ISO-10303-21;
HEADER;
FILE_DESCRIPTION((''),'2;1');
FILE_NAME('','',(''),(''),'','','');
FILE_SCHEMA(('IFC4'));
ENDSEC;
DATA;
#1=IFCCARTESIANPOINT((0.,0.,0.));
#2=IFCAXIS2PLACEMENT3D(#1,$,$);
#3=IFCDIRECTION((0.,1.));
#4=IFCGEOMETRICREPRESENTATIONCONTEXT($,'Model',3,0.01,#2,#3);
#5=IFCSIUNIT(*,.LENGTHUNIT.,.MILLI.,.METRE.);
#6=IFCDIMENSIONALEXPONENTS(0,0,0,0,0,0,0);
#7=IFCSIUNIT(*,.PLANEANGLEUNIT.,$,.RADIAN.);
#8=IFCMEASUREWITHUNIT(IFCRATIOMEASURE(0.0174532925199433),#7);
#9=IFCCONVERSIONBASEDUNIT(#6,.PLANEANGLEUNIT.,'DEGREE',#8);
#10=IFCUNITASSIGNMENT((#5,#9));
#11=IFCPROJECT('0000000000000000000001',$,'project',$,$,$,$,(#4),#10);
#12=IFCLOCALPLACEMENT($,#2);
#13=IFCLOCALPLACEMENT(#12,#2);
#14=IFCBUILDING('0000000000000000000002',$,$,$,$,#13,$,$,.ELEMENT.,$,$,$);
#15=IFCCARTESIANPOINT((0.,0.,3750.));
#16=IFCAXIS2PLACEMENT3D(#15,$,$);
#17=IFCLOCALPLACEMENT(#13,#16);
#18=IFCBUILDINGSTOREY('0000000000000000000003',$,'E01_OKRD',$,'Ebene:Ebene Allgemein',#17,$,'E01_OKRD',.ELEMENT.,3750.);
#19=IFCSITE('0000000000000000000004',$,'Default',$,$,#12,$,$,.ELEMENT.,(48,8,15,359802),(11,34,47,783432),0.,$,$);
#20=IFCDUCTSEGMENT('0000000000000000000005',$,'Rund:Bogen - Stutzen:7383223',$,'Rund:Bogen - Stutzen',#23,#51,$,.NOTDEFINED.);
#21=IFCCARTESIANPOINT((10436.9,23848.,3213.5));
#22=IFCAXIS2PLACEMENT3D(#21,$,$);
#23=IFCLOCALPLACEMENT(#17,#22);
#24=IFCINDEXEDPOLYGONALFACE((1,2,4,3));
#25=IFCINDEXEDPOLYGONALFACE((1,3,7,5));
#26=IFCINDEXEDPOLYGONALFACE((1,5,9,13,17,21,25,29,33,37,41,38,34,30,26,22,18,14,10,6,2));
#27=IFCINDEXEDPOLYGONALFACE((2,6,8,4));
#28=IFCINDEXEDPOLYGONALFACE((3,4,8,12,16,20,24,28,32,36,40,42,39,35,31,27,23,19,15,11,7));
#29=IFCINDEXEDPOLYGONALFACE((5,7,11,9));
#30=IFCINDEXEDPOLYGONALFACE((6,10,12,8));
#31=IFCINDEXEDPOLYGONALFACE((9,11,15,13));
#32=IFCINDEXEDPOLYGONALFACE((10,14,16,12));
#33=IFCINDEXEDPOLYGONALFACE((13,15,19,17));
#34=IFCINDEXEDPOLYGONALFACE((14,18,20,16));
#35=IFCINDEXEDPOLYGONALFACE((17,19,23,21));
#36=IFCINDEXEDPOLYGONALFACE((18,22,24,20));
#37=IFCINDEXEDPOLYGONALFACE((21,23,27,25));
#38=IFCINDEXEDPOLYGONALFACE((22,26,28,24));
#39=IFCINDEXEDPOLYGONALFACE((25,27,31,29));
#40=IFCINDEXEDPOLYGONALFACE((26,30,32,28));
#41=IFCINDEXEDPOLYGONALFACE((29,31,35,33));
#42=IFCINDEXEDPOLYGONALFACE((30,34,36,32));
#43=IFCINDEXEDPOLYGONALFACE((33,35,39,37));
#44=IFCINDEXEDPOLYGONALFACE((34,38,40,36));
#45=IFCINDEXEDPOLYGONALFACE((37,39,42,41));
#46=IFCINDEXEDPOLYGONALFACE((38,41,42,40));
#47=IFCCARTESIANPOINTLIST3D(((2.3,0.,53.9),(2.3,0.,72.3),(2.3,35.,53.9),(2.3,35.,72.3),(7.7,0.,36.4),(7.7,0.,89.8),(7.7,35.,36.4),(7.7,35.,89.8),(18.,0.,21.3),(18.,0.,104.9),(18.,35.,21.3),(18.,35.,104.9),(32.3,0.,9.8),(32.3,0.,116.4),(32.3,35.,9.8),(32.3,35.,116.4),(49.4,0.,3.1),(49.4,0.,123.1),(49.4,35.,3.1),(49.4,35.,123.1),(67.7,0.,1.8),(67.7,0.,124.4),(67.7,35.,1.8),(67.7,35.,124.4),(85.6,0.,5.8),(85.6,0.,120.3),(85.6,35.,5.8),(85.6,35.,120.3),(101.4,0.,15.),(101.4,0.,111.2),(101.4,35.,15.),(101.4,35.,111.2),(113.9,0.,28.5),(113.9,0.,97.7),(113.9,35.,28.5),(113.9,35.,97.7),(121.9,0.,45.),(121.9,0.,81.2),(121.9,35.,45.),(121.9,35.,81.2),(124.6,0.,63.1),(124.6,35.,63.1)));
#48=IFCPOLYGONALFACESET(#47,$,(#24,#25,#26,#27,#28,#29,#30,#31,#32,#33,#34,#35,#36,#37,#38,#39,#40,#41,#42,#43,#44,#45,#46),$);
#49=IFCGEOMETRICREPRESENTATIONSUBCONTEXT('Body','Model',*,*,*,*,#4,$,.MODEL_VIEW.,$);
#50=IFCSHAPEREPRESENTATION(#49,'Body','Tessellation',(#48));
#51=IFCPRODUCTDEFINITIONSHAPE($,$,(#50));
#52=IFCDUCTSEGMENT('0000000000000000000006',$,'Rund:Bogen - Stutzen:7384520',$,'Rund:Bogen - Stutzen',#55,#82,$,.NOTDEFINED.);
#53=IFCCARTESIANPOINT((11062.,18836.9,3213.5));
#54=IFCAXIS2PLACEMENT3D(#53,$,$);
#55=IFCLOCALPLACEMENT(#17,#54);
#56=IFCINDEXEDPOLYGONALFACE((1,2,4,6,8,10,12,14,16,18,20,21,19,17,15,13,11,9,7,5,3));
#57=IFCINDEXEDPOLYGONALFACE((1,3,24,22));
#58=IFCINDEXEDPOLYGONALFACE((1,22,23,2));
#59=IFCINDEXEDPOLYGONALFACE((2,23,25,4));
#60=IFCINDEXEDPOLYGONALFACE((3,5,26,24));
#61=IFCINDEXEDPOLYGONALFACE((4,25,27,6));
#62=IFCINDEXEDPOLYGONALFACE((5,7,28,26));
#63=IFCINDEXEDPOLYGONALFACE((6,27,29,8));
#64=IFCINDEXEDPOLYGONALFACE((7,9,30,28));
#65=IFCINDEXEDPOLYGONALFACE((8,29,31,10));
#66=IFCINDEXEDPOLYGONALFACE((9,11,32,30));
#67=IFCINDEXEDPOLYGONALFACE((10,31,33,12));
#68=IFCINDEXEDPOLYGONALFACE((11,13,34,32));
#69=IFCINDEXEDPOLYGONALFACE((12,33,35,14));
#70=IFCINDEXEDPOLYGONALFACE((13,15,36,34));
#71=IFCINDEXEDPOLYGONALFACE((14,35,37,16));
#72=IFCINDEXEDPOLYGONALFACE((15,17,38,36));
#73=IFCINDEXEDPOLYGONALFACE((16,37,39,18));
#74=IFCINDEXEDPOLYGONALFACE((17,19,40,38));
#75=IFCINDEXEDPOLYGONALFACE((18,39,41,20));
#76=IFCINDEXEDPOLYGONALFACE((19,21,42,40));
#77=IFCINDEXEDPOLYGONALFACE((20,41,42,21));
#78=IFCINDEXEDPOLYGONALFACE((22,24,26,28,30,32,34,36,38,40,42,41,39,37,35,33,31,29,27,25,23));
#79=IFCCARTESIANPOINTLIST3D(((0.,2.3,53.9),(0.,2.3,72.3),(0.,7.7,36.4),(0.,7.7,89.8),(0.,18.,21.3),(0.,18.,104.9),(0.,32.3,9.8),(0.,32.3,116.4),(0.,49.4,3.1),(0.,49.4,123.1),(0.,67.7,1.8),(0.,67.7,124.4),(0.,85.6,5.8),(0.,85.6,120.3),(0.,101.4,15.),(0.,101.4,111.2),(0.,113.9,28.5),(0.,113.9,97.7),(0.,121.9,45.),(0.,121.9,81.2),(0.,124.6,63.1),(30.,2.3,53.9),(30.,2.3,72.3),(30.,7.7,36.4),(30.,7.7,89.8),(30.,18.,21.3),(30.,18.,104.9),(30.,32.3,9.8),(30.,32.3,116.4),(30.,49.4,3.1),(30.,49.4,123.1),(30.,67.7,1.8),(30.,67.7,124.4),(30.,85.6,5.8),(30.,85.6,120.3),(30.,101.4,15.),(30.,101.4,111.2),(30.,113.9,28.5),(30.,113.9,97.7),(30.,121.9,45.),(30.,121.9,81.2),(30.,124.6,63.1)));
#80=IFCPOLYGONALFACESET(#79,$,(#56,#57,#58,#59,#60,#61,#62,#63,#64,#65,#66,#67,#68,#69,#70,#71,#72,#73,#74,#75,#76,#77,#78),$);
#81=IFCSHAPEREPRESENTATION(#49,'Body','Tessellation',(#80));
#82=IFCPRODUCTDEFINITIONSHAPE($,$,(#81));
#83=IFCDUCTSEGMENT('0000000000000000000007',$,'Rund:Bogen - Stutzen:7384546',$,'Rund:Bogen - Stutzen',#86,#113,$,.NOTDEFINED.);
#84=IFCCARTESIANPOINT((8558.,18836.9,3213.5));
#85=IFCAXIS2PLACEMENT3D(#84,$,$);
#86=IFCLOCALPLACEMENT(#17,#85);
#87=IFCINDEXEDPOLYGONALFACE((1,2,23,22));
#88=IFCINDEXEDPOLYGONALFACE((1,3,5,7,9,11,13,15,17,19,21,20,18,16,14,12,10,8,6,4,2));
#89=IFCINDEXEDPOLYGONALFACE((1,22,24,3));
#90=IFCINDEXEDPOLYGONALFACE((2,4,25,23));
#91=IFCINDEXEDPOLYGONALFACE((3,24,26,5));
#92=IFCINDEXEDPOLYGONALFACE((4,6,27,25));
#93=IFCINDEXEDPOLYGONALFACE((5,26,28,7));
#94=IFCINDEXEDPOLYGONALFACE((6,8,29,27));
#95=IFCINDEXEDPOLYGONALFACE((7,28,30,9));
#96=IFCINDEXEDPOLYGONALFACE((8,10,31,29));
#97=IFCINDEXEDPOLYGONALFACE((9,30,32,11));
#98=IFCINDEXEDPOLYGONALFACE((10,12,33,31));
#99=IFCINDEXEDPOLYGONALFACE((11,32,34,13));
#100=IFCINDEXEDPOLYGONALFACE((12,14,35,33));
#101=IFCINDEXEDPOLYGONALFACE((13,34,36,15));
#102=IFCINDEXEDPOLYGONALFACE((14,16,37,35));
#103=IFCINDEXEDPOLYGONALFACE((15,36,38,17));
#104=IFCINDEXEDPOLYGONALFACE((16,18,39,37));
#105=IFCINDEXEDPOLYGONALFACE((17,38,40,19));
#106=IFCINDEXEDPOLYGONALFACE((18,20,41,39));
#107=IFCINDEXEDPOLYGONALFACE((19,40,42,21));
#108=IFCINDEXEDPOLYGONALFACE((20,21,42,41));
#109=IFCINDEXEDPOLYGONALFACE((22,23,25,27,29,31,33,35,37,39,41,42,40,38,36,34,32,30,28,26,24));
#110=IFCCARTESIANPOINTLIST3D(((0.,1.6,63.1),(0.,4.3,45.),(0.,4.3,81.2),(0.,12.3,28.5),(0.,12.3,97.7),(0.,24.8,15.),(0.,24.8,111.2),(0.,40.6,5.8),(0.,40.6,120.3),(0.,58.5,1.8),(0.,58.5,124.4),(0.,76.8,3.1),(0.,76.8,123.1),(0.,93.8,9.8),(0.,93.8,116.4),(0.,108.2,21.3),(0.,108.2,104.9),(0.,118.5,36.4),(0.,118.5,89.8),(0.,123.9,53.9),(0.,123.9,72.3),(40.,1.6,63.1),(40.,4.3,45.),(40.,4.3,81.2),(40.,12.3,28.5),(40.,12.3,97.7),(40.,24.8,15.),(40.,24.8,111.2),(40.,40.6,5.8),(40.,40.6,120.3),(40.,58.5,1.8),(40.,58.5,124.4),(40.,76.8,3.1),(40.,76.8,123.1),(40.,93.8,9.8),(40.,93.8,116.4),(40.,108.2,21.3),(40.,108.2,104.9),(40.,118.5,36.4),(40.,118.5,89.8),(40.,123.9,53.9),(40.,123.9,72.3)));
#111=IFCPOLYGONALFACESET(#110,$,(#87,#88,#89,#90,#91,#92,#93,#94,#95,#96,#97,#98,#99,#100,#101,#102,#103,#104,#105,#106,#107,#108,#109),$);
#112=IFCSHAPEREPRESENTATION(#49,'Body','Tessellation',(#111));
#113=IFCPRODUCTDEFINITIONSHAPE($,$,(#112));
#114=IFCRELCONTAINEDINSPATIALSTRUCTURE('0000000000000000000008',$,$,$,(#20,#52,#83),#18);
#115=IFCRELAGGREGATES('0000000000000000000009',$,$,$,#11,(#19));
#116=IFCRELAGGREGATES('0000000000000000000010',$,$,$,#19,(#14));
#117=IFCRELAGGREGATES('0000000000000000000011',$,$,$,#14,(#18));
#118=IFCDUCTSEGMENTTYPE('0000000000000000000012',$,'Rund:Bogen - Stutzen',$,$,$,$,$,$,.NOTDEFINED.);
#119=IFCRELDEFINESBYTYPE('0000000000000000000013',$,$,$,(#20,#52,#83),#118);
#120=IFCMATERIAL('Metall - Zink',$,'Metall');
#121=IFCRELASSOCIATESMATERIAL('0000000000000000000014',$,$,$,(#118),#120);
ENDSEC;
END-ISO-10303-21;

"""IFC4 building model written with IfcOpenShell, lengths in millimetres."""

from ifc_helpers import new_model, entity, si_unit, converted_unit, direction, frame, frame_2d, origin, origin_2d_with_axis, place, context, subcontext, project, spatial, circle, extrude, material, type_object, element, save


model = new_model("IFC4")

# Units and contexts
model_context = context("Model", 3, precision=0.01, world=origin(), true_north=direction((0.0, 1.0)))
body_context = subcontext(model_context, "Body", "Model", "MODEL_VIEW")
ifc_project = project(units=[si_unit("LENGTHUNIT", "METRE", prefix="MILLI"), converted_unit("PLANEANGLEUNIT", "DEGREE", entity("IfcRatioMeasure", 0.0174532925199433), si_unit("PLANEANGLEUNIT", "RADIAN"), dimensions=[0, 0, 0, 0, 0, 0, 0])], contexts=[model_context])

# Site, building, storey
site_placement = place(None, origin())
site = spatial("IfcSite", under=ifc_project, at=site_placement, Name="Default", CompositionType="ELEMENT", RefLatitude=(48, 8, 15, 359802), RefLongitude=(11, 34, 47, 783432), RefElevation=0.0)
building_placement = place(site_placement, origin())
building = spatial("IfcBuilding", under=site, at=building_placement, CompositionType="ELEMENT")
storey_placement = place(building_placement, frame((0.0, 0.0, 3750.0)))
storey = spatial("IfcBuildingStorey", under=building, at=storey_placement, Name="E01_OKRD", ObjectType="Ebene:Ebene Allgemein", LongName="E01_OKRD", CompositionType="ELEMENT", Elevation=3750.0)

# Shared definitions
ifc_material_1 = material(Name="Metall - Zink", Category="Metall")

# Duct segments
duct_segment_type_1 = type_object("IfcDuctSegmentType", Name="Rund:Bogen - Stutzen", PredefinedType="NOTDEFINED", material=ifc_material_1)
duct_segment_1_placement = place(storey_placement, frame((10436.9, 23848.0, 3213.5)))
element("IfcDuctSegment", 1, at=duct_segment_1_placement, inside=storey, type_object=duct_segment_type_1, Name="Rund:Bogen - Stutzen:7383223", ObjectType="Rund:Bogen - Stutzen", PredefinedType="NOTDEFINED", context=body_context, shape_type="SweptSolid", body=[
    extrude(circle(Radius=61.5, at=origin_2d_with_axis()), frame((63.1, 0.0, 63.1), z_axis=(0.0, 1.0, 0.0), x_axis=(1.0, 0.0, 0.0)), (0.0, 0.0, 1.0), 35.0),
])
duct_segment_2_placement = place(storey_placement, frame((11062.0, 18836.9, 3213.5)))
element("IfcDuctSegment", 2, at=duct_segment_2_placement, inside=storey, type_object=duct_segment_type_1, Name="Rund:Bogen - Stutzen:7384520", ObjectType="Rund:Bogen - Stutzen", PredefinedType="NOTDEFINED", context=body_context, shape_type="SweptSolid", body=[
    extrude(circle(Radius=61.5, at=frame_2d((0.0, 0.0), x_axis=(1.0, 0.0))), frame((0.0, 63.1, 63.1), z_axis=(1.0, 0.0, 0.0), x_axis=(0.0, 1.0, 0.0)), (0.0, 0.0, 1.0), 30.0),
])
duct_segment_3_placement = place(storey_placement, frame((8558.0, 18836.9, 3213.5)))
element("IfcDuctSegment", 3, at=duct_segment_3_placement, inside=storey, type_object=duct_segment_type_1, Name="Rund:Bogen - Stutzen:7384546", ObjectType="Rund:Bogen - Stutzen", PredefinedType="NOTDEFINED", context=body_context, shape_type="SweptSolid", body=[
    extrude(circle(Radius=61.5, at=origin_2d_with_axis()), frame((0.0, 63.1, 63.1), z_axis=(1.0, 0.0, 0.0), x_axis=(0.0, -1.0, 0.0)), (0.0, 0.0, 1.0), 40.0),
])

save(model, "model.ifc")
